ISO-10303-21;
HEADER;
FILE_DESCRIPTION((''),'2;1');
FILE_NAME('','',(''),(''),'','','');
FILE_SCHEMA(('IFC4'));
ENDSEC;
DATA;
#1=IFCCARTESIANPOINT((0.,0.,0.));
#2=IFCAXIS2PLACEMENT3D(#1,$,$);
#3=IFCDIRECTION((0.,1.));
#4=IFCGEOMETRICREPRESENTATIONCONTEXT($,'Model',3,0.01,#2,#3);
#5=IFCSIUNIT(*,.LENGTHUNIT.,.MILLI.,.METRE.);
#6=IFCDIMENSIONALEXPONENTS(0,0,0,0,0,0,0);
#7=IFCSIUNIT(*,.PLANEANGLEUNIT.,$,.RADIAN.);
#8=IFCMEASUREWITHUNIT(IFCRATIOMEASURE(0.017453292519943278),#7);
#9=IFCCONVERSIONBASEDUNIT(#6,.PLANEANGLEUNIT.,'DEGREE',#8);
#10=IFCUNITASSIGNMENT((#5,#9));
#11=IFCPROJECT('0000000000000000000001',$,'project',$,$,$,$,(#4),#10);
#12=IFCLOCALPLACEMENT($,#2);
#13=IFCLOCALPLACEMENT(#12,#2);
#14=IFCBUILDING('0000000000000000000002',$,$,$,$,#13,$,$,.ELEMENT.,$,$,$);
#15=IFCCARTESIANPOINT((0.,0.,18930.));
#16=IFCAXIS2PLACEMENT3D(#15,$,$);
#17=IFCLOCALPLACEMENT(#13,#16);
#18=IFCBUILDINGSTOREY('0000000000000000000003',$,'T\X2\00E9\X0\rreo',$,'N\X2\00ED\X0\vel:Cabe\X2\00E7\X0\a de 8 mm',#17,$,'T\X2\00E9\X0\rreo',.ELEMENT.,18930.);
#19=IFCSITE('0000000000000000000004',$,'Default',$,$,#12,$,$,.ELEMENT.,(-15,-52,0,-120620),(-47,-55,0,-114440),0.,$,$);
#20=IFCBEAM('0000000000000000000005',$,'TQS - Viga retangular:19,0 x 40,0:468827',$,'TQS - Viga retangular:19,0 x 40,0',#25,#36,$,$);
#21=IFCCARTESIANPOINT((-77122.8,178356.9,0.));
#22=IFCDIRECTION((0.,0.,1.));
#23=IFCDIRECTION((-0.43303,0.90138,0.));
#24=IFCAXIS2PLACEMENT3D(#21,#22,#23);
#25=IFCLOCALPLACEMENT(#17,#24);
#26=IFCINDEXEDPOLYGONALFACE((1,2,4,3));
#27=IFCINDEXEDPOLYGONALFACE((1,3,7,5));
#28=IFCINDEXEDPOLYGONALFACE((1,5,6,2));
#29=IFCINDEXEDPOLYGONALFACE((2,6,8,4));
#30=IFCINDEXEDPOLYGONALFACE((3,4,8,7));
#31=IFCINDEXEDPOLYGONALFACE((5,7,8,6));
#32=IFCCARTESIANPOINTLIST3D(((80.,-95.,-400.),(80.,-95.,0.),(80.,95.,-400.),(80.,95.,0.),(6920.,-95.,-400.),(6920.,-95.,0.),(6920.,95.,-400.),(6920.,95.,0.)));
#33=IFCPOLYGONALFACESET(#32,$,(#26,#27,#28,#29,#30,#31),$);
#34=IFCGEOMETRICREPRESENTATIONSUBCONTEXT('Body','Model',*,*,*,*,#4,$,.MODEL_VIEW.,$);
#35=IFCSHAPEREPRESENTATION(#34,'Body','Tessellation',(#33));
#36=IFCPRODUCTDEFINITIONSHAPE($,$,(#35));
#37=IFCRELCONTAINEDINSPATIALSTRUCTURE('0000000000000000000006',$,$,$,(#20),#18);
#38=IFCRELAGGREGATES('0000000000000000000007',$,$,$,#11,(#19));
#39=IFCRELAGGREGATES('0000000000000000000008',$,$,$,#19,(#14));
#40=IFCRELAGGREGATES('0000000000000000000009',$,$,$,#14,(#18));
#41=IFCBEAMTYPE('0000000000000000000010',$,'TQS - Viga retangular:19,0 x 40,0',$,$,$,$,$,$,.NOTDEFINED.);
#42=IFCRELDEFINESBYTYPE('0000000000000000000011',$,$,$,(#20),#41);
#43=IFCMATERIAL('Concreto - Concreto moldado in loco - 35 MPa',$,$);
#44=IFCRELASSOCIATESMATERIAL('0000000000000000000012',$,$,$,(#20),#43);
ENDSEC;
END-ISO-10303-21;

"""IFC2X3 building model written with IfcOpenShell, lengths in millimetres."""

from ifc_helpers import new_model, entity, si_unit, converted_unit, direction, frame, frame_2d, origin, place, context, subcontext, project, spatial, rectangle, extrude, material, type_object, element, save


model = new_model("IFC2X3")

# Units and contexts
model_context = context("Model", 3, precision=0.01, world=origin(), true_north=direction((0.0, 1.0)))
body_context = subcontext(model_context, "Body", "Model", "MODEL_VIEW")
ifc_project = project(units=[si_unit("LENGTHUNIT", "METRE", prefix="MILLI"), converted_unit("PLANEANGLEUNIT", "DEGREE", entity("IfcRatioMeasure", 0.017453292519943278), si_unit("PLANEANGLEUNIT", "RADIAN"), dimensions=[0, 0, 0, 0, 0, 0, 0])], contexts=[model_context])

# Site, building, storey
site_placement = place(None, origin())
site = spatial("IfcSite", under=ifc_project, at=site_placement, Name="Default", CompositionType="ELEMENT", RefLatitude=(-15, -52, 0, -120620), RefLongitude=(-47, -55, 0, -114440), RefElevation=0.0)
building_placement = place(site_placement, origin())
building = spatial("IfcBuilding", under=site, at=building_placement, CompositionType="ELEMENT")
storey_placement = place(building_placement, frame((0.0, 0.0, 18930.0)))
storey = spatial("IfcBuildingStorey", under=building, at=storey_placement, Name="Térreo", ObjectType="Nível:Cabeça de 8 mm", LongName="Térreo", CompositionType="ELEMENT", Elevation=18930.0)

# Beam
ifc_material_1 = material(Name="Concreto - Concreto moldado in loco - 35 MPa")
beam_type_1 = type_object("IfcBeamType", Name="TQS - Viga retangular:19,0 x 40,0", PredefinedType="NOTDEFINED")
beam_1_placement = place(storey_placement, frame((-77122.8, 178356.9, 0.0), z_axis=(0.0, 0.0, 1.0), x_axis=(-0.43303, 0.90138, 0.0)))
element("IfcBeam", 1, at=beam_1_placement, inside=storey, type_object=beam_type_1, material=ifc_material_1, Name="TQS - Viga retangular:19,0 x 40,0:468827", ObjectType="TQS - Viga retangular:19,0 x 40,0", context=body_context, shape_type="SweptSolid", body=[
    extrude(rectangle(XDim=400.0, YDim=190.0, at=frame_2d((0.0, 0.0), x_axis=(1.0, 0.0))), frame((80.0, 0.0, -200.0), z_axis=(1.0, 0.0, 0.0), x_axis=(0.0, 0.0, -1.0)), (0.0, 0.0, 1.0), 6840.0),
])

save(model, "model.ifc")
